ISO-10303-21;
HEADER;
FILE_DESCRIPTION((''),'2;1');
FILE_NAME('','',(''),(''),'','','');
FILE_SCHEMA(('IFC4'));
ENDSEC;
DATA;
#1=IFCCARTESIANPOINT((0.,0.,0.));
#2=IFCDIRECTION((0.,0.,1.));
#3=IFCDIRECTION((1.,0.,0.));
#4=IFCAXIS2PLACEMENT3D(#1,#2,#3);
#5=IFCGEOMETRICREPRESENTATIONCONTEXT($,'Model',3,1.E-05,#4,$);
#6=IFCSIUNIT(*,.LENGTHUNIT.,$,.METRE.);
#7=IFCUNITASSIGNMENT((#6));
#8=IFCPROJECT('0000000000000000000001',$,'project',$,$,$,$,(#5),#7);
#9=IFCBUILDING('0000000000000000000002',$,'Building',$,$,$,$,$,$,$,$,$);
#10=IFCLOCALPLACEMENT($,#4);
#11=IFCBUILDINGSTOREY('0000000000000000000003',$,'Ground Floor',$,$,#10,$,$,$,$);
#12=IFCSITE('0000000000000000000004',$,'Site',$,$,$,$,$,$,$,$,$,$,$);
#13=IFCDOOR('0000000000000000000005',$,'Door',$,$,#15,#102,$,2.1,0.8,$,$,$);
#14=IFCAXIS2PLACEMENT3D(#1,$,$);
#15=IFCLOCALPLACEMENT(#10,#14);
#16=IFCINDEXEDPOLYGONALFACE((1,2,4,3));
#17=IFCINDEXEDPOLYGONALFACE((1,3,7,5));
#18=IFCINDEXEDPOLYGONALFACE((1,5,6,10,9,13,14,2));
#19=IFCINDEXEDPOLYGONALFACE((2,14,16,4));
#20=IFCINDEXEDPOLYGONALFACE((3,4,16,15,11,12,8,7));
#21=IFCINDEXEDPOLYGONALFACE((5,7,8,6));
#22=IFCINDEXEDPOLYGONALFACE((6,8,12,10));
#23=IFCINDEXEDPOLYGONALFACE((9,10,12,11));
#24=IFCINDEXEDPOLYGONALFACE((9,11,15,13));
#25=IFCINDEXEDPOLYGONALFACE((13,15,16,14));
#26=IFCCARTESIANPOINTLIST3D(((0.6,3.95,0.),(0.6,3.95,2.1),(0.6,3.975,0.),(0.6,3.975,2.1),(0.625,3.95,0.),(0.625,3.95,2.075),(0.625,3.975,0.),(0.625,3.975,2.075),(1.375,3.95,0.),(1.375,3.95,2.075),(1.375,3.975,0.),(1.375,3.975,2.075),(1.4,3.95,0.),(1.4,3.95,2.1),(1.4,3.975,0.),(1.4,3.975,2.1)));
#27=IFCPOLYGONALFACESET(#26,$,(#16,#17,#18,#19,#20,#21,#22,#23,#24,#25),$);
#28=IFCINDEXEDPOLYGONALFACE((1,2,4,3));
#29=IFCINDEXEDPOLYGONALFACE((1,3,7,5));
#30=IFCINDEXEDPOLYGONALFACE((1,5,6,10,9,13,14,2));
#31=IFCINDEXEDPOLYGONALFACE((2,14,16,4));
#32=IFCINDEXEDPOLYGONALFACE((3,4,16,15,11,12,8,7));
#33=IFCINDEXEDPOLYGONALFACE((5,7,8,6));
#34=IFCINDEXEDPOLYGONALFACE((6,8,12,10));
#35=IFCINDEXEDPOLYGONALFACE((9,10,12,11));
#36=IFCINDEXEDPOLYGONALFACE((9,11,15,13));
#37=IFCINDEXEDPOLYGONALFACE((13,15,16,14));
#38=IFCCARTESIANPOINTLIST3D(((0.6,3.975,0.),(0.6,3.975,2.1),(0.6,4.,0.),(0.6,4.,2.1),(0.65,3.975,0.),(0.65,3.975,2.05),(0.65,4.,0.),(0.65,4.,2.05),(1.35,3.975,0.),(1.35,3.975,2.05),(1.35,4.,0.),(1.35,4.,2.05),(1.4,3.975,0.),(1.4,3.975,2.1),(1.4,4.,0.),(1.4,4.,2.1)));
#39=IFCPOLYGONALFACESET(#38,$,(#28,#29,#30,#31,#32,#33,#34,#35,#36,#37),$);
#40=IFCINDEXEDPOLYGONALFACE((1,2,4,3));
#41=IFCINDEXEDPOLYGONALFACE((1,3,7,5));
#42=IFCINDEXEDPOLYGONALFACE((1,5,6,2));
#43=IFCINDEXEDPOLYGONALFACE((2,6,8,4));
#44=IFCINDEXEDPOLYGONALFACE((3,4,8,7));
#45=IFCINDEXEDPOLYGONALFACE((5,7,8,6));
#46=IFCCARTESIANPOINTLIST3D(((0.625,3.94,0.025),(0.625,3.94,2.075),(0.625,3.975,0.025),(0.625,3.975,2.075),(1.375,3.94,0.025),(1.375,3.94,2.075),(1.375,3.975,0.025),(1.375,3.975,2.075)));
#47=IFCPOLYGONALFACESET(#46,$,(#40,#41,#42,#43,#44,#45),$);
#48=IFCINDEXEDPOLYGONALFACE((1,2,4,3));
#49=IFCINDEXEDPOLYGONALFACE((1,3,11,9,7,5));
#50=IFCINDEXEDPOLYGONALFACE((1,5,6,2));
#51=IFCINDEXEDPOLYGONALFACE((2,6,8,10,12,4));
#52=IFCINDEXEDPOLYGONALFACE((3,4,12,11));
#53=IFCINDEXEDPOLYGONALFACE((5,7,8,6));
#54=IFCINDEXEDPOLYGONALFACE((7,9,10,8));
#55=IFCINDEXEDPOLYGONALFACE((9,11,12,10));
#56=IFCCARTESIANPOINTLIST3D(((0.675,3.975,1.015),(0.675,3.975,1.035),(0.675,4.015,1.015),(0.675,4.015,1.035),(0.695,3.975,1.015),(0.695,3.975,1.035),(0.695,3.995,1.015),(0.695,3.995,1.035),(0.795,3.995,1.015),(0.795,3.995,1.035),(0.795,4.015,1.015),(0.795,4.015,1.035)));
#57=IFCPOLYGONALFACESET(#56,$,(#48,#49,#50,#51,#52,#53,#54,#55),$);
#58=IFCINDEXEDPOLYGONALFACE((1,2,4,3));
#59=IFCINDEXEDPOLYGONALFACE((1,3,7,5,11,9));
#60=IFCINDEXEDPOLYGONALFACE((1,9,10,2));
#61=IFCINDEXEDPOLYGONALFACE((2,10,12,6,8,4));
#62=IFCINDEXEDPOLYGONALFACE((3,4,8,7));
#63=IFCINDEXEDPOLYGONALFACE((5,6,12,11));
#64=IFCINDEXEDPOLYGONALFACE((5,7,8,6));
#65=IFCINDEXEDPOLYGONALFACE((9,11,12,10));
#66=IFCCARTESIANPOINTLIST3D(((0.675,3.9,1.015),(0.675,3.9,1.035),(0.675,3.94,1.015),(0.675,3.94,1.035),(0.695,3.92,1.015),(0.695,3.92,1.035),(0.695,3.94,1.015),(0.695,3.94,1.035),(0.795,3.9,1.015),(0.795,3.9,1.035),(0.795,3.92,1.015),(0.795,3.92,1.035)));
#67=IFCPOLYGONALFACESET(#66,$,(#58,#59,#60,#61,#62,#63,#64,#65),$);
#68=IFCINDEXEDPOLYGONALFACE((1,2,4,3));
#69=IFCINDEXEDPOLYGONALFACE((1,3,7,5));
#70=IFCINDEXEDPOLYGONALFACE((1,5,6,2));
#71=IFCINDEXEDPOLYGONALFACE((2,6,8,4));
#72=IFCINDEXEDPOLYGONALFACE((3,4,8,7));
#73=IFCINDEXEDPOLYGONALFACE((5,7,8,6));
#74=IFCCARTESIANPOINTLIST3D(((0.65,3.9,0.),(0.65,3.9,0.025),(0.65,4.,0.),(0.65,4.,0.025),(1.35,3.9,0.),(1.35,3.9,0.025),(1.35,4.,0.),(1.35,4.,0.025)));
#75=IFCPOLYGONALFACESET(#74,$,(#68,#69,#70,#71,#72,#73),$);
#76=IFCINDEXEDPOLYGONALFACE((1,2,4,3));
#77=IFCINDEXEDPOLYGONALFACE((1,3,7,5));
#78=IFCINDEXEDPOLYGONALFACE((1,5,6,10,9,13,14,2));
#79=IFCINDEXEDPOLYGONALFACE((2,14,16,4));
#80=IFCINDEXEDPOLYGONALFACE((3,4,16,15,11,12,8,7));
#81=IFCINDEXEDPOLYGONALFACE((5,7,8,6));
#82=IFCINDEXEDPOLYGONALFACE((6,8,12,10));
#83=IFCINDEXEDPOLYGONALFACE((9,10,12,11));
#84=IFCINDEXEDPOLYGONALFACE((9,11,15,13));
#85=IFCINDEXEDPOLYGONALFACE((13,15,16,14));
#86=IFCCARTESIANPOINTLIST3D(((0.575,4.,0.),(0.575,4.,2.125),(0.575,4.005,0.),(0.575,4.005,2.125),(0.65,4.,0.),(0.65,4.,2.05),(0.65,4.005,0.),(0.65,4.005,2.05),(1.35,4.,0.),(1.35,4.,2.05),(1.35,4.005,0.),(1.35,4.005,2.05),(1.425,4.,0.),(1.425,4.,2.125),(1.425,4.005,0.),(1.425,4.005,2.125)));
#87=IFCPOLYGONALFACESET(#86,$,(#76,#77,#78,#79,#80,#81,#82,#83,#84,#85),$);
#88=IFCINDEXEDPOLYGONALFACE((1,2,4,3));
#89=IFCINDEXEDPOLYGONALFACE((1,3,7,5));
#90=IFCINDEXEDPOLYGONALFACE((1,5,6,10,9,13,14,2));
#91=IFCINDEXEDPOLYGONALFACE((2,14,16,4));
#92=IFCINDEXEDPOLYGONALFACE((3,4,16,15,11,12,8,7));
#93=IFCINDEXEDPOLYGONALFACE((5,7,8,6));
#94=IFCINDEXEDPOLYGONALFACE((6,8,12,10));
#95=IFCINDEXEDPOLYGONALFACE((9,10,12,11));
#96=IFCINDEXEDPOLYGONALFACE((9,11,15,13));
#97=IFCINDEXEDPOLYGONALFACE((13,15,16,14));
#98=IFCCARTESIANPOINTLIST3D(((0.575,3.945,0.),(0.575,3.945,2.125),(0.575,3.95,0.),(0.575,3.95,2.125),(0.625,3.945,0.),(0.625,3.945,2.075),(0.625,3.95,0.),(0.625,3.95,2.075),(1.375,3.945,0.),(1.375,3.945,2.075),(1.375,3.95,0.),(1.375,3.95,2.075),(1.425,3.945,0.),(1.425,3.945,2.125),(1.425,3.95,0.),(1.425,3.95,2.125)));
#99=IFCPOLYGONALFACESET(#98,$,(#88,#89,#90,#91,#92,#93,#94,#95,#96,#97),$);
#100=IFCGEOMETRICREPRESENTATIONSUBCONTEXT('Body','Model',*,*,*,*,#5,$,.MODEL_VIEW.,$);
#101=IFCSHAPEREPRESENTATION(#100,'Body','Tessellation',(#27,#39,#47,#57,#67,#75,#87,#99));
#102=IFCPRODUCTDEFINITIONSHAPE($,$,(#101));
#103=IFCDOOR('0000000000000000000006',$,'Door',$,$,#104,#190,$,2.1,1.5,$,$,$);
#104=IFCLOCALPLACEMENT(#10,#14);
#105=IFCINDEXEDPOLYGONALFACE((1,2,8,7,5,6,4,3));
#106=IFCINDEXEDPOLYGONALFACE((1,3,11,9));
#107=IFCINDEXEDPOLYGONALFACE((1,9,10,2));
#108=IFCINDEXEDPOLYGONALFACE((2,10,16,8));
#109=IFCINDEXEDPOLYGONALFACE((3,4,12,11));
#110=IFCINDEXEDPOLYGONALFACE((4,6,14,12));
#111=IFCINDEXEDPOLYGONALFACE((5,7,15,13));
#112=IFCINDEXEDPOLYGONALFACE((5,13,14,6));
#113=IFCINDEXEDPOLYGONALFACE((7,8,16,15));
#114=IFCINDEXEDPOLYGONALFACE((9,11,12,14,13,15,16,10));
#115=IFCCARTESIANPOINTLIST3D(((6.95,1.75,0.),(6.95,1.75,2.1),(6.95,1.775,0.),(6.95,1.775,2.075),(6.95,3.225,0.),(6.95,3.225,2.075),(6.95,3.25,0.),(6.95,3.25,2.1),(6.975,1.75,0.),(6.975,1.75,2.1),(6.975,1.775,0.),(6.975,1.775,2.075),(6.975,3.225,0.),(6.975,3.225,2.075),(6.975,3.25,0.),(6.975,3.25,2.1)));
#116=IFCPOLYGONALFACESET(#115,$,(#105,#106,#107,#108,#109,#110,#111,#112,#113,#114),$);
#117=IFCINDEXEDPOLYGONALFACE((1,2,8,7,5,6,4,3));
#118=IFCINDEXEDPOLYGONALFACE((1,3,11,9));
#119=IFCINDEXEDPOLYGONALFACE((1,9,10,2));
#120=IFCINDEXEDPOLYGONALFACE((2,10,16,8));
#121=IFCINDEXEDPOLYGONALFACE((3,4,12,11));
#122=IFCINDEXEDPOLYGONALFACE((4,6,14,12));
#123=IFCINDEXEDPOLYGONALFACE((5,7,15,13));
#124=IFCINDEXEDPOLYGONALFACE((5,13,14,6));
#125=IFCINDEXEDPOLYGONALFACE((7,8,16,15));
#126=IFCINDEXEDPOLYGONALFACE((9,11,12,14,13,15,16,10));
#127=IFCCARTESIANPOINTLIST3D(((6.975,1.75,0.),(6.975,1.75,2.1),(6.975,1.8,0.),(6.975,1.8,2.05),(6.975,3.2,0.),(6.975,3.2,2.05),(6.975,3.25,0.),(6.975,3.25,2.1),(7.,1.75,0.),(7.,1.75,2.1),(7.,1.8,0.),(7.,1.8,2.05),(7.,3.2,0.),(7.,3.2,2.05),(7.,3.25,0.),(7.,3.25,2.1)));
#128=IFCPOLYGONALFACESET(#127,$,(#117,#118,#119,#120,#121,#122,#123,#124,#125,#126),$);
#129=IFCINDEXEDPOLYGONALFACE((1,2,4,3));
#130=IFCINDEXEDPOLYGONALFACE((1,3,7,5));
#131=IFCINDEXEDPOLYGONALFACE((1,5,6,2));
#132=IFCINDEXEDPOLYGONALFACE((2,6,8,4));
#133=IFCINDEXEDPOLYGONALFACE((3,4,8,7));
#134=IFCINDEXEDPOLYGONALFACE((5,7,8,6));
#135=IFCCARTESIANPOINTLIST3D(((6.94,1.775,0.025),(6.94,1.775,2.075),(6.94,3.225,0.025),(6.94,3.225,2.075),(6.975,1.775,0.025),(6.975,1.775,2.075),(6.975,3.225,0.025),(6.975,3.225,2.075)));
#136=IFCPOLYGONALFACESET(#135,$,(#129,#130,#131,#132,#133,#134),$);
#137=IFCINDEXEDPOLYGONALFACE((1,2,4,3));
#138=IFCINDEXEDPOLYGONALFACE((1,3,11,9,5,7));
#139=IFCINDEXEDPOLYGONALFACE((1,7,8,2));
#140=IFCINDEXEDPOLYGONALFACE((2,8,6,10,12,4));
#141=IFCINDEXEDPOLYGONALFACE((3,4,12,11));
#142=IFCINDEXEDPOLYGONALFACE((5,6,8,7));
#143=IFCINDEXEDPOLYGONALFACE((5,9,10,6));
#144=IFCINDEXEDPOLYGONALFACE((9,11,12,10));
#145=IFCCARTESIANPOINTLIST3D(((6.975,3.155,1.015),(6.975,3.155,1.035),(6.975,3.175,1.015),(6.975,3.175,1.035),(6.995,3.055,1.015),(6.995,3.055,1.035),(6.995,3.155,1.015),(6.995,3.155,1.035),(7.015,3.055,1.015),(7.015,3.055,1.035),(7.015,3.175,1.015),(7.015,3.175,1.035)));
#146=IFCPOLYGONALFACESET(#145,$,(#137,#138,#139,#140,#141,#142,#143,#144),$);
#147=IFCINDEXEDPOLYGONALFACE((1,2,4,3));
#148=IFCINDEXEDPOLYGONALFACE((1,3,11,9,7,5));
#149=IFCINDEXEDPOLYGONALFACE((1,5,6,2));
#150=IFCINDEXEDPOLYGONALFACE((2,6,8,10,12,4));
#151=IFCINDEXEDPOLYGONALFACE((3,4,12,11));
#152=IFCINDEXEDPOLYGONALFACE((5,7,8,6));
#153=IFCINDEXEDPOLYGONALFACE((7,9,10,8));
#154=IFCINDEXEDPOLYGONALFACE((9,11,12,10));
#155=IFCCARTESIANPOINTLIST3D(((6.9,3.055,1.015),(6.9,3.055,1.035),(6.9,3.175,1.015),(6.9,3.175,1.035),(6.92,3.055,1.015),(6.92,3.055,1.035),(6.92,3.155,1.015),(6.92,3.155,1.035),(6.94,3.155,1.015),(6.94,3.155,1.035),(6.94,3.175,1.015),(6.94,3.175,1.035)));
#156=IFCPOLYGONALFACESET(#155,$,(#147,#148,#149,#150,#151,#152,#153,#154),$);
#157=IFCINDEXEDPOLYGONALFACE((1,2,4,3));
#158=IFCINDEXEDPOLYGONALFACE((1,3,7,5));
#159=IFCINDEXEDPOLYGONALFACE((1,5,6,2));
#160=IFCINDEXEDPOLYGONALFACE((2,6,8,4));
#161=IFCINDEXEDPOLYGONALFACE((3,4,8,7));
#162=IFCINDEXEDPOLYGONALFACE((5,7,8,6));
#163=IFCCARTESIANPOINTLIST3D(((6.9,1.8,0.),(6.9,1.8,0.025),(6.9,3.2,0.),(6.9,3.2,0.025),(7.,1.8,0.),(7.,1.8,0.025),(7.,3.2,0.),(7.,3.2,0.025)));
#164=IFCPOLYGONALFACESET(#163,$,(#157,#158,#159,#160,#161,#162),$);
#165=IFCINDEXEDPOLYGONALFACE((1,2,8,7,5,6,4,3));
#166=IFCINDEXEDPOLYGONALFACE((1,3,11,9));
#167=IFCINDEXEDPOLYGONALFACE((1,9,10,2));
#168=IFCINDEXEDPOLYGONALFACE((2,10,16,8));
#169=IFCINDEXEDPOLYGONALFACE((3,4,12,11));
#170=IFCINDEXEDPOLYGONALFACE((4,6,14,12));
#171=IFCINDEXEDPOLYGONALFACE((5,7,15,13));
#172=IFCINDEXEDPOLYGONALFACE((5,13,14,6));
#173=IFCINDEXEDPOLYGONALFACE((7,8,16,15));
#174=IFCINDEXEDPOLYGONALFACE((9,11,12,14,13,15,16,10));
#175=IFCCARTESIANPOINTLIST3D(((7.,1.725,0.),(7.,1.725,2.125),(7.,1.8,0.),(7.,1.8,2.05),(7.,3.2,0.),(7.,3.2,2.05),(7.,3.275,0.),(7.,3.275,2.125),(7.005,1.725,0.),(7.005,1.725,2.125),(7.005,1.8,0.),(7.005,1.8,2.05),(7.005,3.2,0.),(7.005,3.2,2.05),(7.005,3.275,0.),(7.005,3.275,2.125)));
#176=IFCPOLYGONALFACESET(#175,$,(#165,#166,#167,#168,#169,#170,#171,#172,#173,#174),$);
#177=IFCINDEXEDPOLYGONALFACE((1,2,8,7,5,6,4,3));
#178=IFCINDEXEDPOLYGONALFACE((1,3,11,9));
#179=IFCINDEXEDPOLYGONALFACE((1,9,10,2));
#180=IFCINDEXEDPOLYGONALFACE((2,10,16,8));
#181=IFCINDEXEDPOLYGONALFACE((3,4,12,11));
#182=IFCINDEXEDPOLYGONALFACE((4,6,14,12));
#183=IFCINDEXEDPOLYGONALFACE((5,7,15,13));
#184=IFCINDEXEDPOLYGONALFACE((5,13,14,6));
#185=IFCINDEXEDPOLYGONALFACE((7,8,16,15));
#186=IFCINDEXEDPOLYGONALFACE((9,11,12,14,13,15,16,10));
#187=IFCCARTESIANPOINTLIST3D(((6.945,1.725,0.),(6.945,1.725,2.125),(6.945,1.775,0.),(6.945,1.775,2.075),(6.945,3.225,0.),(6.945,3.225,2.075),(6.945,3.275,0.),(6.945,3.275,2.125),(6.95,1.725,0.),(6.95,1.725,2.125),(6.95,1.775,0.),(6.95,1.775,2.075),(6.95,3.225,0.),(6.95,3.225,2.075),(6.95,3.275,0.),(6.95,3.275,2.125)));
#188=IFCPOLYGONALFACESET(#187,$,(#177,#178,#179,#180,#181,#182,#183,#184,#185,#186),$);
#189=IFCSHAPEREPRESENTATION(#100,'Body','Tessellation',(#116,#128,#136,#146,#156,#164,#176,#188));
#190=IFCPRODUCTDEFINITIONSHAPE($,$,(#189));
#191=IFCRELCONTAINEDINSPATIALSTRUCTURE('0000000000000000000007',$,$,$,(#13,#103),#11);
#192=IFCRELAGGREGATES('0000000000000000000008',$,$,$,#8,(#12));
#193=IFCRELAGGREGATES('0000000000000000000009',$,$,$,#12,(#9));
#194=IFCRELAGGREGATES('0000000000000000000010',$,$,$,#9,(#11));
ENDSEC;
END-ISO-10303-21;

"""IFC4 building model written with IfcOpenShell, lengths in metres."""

from ifc_helpers import new_model, si_unit, frame, origin_with_axes, place, context, subcontext, project, spatial, line, indexed_curve, outline, extrude, element, save


model = new_model("IFC4")

# Units and contexts
model_context = context("Model", 3, precision=1e-05, world=origin_with_axes())
body_context = subcontext(model_context, "Body", "Model", "MODEL_VIEW")
ifc_project = project(units=[si_unit("LENGTHUNIT", "METRE")], contexts=[model_context])

# Site, building, storey
site = spatial("IfcSite", under=ifc_project, Name="Site")
building = spatial("IfcBuilding", under=site, Name="Building")
storey_placement = place(None, origin_with_axes())
storey = spatial("IfcBuildingStorey", under=building, at=storey_placement, Name="Ground Floor")

# Doors
door_1_placement = place(storey_placement, frame((1.4, 4.0, 0.0), z_axis=(0.0, 0.0, 1.0), x_axis=(-1.0, 0.0, 0.0)))
element("IfcDoor", 1, at=door_1_placement, inside=storey, Name="Door", OverallHeight=2.1, OverallWidth=0.8, context=body_context, shape_type="SweptSolid", body=[
    extrude(outline(indexed_curve([(0.0, 0.0), (0.0, 2.1), (0.8, 2.1), (0.8, 0.0), (0.775, 0.0), (0.775, 2.075), (0.025, 2.075), (0.025, 0.0)], segments=[line(1, 2, 3, 4, 5, 6, 7, 8, 1)])), frame((0.0, 0.025, 0.0), z_axis=(0.0, -1.0, 0.0), x_axis=(1.0, 0.0, 0.0)), (0.0, 0.0, -1.0), 0.025),
    extrude(outline(indexed_curve([(0.0, 0.0), (0.0, 2.1), (0.8, 2.1), (0.8, 0.0), (0.75, 0.0), (0.75, 2.05), (0.05, 2.05), (0.05, 0.0)], segments=[line(1, 2, 3, 4, 5, 6, 7, 8, 1)])), frame((0.0, 0.0, 0.0), z_axis=(0.0, -1.0, 0.0), x_axis=(1.0, 0.0, 0.0)), (0.0, 0.0, -1.0), 0.025),
    extrude(outline(indexed_curve([(0.0, 0.0), (0.75, 0.0), (0.75, 0.035), (0.0, 0.035)], segments=[line(1, 2, 3, 4, 1)])), frame((0.025, 0.025, 0.025), z_axis=(0.0, 0.0, 1.0), x_axis=(1.0, 0.0, 0.0)), (0.0, 0.0, 1.0), 2.05),
    extrude(outline(indexed_curve([(0.0, 0.0), (0.0, -0.04), (-0.12, -0.04), (-0.12, -0.02), (-0.02, -0.02), (-0.02, 0.0)], segments=[line(1, 2, 3, 4, 5, 6, 1)])), frame((0.725, 0.025, 1.015), z_axis=(0.0, 0.0, 1.0), x_axis=(1.0, 0.0, 0.0)), (0.0, 0.0, 1.0), 0.02),
    extrude(outline(indexed_curve([(0.0, 0.0), (0.0, 0.04), (-0.12, 0.04), (-0.12, 0.02), (-0.02, 0.02), (-0.02, 0.0)], segments=[line(1, 2, 3, 4, 5, 6, 1)])), frame((0.725, 0.06, 1.015), z_axis=(0.0, 0.0, 1.0), x_axis=(1.0, 0.0, 0.0)), (0.0, 0.0, 1.0), 0.02),
    extrude(outline(indexed_curve([(0.0, 0.0), (0.7, 0.0), (0.7, 0.1), (0.0, 0.1)], segments=[line(1, 2, 3, 4, 1)])), frame((0.05, 0.0, 0.0), z_axis=(0.0, 0.0, 1.0), x_axis=(1.0, 0.0, 0.0)), (0.0, 0.0, 1.0), 0.025),
    extrude(outline(indexed_curve([(0.0, 0.0), (0.0, 2.125), (0.85, 2.125), (0.85, 0.0), (0.775, 0.0), (0.775, 2.05), (0.075, 2.05), (0.075, 0.0)], segments=[line(1, 2, 3, 4, 5, 6, 7, 8, 1)])), frame((-0.025, -0.005, 0.0), z_axis=(0.0, -1.0, 0.0), x_axis=(1.0, 0.0, 0.0)), (0.0, 0.0, -1.0), 0.005),
    extrude(outline(indexed_curve([(0.0, 0.0), (0.0, 2.125), (0.85, 2.125), (0.85, 0.0), (0.8, 0.0), (0.8, 2.075), (0.05, 2.075), (0.05, 0.0)], segments=[line(1, 2, 3, 4, 5, 6, 7, 8, 1)])), frame((-0.025, 0.05, 0.0), z_axis=(0.0, -1.0, 0.0), x_axis=(1.0, 0.0, 0.0)), (0.0, 0.0, -1.0), 0.005),
])
door_2_placement = place(storey_placement, frame((7.0, 1.75, 0.0), z_axis=(0.0, 0.0, 1.0), x_axis=(0.0, 1.0, 0.0)))
element("IfcDoor", 2, at=door_2_placement, inside=storey, Name="Door", OverallHeight=2.1, OverallWidth=1.5, context=body_context, shape_type="SweptSolid", body=[
    extrude(outline(indexed_curve([(0.0, 0.0), (0.0, 2.1), (1.5, 2.1), (1.5, 0.0), (1.475, 0.0), (1.475, 2.075), (0.025, 2.075), (0.025, 0.0)], segments=[line(1, 2, 3, 4, 5, 6, 7, 8, 1)])), frame((0.0, 0.025, 0.0), z_axis=(0.0, -1.0, 0.0), x_axis=(1.0, 0.0, 0.0)), (0.0, 0.0, -1.0), 0.025),
    extrude(outline(indexed_curve([(0.0, 0.0), (0.0, 2.1), (1.5, 2.1), (1.5, 0.0), (1.45, 0.0), (1.45, 2.05), (0.05, 2.05), (0.05, 0.0)], segments=[line(1, 2, 3, 4, 5, 6, 7, 8, 1)])), frame((0.0, 0.0, 0.0), z_axis=(0.0, -1.0, 0.0), x_axis=(1.0, 0.0, 0.0)), (0.0, 0.0, -1.0), 0.025),
    extrude(outline(indexed_curve([(0.0, 0.0), (1.45, 0.0), (1.45, 0.035), (0.0, 0.035)], segments=[line(1, 2, 3, 4, 1)])), frame((0.025, 0.025, 0.025), z_axis=(0.0, 0.0, 1.0), x_axis=(1.0, 0.0, 0.0)), (0.0, 0.0, 1.0), 2.05),
    extrude(outline(indexed_curve([(0.0, 0.0), (0.0, -0.04), (-0.12, -0.04), (-0.12, -0.02), (-0.02, -0.02), (-0.02, 0.0)], segments=[line(1, 2, 3, 4, 5, 6, 1)])), frame((1.425, 0.025, 1.015), z_axis=(0.0, 0.0, 1.0), x_axis=(1.0, 0.0, 0.0)), (0.0, 0.0, 1.0), 0.02),
    extrude(outline(indexed_curve([(0.0, 0.0), (0.0, 0.04), (-0.12, 0.04), (-0.12, 0.02), (-0.02, 0.02), (-0.02, 0.0)], segments=[line(1, 2, 3, 4, 5, 6, 1)])), frame((1.425, 0.06, 1.015), z_axis=(0.0, 0.0, 1.0), x_axis=(1.0, 0.0, 0.0)), (0.0, 0.0, 1.0), 0.02),
    extrude(outline(indexed_curve([(0.0, 0.0), (1.4, 0.0), (1.4, 0.1), (0.0, 0.1)], segments=[line(1, 2, 3, 4, 1)])), frame((0.05, 0.0, 0.0), z_axis=(0.0, 0.0, 1.0), x_axis=(1.0, 0.0, 0.0)), (0.0, 0.0, 1.0), 0.025),
    extrude(outline(indexed_curve([(0.0, 0.0), (0.0, 2.125), (1.55, 2.125), (1.55, 0.0), (1.475, 0.0), (1.475, 2.05), (0.075, 2.05), (0.075, 0.0)], segments=[line(1, 2, 3, 4, 5, 6, 7, 8, 1)])), frame((-0.025, -0.005, 0.0), z_axis=(0.0, -1.0, 0.0), x_axis=(1.0, 0.0, 0.0)), (0.0, 0.0, -1.0), 0.005),
    extrude(outline(indexed_curve([(0.0, 0.0), (0.0, 2.125), (1.55, 2.125), (1.55, 0.0), (1.5, 0.0), (1.5, 2.075), (0.05, 2.075), (0.05, 0.0)], segments=[line(1, 2, 3, 4, 5, 6, 7, 8, 1)])), frame((-0.025, 0.05, 0.0), z_axis=(0.0, -1.0, 0.0), x_axis=(1.0, 0.0, 0.0)), (0.0, 0.0, -1.0), 0.005),
])

save(model, "model.ifc")
